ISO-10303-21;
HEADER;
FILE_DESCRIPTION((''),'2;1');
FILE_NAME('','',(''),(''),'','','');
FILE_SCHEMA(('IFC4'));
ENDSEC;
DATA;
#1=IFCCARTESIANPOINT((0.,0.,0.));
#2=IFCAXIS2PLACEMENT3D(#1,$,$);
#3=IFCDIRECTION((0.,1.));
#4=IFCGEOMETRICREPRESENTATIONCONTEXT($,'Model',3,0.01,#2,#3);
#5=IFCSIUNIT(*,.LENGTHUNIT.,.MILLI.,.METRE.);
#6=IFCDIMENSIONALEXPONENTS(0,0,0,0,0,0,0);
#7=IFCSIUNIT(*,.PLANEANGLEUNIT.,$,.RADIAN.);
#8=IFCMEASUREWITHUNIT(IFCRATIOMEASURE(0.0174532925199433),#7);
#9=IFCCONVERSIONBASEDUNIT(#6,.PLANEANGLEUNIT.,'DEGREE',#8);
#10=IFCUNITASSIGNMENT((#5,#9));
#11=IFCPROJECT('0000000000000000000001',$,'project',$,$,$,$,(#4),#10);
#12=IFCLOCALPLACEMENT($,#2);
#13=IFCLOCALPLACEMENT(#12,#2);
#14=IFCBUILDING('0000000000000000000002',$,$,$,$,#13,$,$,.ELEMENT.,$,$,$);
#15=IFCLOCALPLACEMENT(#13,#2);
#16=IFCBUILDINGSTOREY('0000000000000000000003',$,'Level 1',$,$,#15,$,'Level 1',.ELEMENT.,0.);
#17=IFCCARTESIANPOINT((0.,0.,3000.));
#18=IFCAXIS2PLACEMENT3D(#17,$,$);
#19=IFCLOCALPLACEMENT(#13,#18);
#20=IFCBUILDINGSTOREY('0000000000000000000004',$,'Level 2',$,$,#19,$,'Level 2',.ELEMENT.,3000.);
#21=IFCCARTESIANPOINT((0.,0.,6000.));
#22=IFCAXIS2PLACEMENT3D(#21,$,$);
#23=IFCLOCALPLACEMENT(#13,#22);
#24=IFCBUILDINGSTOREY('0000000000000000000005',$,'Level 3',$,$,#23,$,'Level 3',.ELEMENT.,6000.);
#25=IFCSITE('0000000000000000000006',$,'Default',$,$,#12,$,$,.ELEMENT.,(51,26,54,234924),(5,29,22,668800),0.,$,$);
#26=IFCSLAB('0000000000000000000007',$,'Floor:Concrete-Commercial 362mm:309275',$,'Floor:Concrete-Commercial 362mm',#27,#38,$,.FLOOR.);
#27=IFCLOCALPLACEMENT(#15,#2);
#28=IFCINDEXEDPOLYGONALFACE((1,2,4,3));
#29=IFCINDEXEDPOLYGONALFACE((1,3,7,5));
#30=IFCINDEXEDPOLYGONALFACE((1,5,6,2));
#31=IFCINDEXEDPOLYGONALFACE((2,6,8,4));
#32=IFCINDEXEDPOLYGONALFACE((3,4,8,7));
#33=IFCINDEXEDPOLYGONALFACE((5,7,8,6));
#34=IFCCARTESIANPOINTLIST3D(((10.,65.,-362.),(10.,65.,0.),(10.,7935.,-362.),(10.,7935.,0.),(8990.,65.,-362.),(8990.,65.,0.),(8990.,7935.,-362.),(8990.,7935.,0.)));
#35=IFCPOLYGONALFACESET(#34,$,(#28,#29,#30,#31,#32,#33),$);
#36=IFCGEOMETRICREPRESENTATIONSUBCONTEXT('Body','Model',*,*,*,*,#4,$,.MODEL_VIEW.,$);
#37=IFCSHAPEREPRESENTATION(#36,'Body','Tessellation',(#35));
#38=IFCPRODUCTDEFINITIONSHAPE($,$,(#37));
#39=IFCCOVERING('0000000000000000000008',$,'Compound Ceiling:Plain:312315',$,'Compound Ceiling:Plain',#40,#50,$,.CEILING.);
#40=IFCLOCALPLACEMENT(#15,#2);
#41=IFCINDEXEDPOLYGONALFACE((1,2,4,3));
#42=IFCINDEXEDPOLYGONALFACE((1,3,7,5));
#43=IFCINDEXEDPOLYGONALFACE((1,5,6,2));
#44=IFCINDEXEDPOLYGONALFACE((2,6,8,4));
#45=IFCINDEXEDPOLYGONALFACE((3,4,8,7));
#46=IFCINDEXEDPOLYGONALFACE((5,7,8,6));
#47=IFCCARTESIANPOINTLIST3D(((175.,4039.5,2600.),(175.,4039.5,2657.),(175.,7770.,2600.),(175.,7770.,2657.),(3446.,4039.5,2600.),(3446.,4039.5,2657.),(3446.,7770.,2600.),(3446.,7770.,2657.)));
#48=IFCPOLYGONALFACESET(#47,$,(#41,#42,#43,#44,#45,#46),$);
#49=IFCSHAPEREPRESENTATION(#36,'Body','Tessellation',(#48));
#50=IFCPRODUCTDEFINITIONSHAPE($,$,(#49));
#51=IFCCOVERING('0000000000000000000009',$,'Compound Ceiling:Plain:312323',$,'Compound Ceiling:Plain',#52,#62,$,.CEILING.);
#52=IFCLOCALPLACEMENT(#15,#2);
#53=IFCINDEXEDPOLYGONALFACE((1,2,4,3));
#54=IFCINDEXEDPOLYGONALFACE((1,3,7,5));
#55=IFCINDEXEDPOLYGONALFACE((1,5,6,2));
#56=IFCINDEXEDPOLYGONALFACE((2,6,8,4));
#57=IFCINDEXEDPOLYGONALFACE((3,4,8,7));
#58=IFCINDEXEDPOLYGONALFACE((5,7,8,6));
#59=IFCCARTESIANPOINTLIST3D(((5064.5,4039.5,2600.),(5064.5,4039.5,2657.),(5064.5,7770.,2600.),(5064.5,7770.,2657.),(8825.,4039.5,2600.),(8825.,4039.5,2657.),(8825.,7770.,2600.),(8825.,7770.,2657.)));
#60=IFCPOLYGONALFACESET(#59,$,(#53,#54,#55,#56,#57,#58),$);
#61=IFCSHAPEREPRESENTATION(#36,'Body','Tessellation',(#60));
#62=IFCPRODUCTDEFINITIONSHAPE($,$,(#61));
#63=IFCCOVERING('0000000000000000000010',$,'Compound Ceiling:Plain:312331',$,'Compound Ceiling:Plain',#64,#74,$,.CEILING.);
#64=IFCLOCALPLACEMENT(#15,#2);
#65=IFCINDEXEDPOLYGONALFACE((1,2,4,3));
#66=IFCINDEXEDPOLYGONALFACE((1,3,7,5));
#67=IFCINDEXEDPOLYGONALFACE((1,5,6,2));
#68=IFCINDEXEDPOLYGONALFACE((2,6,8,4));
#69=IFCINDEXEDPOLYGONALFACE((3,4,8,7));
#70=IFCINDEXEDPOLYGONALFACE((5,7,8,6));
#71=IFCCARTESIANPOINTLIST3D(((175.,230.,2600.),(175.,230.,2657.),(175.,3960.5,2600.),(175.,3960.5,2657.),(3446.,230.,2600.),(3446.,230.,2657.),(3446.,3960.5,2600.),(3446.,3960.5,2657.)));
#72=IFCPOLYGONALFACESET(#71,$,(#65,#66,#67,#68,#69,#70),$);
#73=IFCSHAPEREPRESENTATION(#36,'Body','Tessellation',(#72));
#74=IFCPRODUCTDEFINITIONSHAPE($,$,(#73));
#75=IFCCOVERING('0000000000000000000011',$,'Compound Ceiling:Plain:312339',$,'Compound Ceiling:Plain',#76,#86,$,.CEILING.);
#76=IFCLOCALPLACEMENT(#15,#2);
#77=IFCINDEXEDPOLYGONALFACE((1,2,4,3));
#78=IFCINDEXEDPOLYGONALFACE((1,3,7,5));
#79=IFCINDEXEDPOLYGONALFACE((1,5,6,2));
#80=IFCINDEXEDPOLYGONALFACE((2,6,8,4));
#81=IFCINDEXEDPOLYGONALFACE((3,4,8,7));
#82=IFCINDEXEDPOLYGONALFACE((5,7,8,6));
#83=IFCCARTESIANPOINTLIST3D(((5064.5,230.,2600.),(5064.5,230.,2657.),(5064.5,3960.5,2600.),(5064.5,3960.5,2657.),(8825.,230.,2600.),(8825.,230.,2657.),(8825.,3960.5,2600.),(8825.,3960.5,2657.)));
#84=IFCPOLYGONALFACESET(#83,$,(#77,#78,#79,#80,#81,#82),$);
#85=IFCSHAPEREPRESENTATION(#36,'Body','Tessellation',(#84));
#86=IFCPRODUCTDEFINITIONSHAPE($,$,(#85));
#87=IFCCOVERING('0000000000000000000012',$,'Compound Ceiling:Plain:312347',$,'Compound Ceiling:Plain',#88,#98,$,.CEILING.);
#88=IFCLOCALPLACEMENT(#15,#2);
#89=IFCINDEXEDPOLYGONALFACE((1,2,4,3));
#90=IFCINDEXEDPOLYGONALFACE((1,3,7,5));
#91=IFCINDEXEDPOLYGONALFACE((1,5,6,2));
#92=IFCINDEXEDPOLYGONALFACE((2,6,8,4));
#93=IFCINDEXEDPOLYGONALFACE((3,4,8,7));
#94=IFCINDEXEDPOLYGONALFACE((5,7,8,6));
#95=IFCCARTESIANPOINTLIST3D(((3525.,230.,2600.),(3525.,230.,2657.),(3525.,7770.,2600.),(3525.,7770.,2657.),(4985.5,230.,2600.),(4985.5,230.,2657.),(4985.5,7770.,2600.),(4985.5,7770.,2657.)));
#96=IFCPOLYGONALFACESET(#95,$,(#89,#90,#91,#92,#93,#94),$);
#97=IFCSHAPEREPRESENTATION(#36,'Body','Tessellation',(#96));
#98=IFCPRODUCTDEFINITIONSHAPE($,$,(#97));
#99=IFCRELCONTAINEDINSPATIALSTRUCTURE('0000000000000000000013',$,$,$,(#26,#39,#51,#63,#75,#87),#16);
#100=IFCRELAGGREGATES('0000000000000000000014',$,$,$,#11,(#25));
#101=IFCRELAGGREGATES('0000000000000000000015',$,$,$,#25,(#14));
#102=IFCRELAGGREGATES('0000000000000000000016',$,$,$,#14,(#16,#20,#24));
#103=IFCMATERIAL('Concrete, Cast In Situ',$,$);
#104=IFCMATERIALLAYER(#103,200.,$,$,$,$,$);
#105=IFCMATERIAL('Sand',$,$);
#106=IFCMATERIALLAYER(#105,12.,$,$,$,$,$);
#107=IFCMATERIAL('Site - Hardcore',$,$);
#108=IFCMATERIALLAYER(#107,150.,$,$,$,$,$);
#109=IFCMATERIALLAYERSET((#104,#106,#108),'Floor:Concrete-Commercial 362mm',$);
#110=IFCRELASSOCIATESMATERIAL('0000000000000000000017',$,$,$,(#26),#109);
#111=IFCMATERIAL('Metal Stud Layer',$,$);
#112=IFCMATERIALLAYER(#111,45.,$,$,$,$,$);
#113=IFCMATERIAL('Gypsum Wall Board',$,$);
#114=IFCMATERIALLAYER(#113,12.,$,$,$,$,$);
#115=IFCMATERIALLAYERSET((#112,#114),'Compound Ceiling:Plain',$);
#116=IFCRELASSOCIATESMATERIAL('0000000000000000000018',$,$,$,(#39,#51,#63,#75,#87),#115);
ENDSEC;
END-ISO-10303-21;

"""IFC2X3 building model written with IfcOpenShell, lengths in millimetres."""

from ifc_helpers import new_model, entity, si_unit, converted_unit, direction, frame, frame_2d, origin, origin_2d_with_axis, place, context, subcontext, project, spatial, rectangle, extrude, material, layer, layer_set, layer_usage, element, save


model = new_model("IFC2X3")

# Units and contexts
model_context = context("Model", 3, precision=0.01, world=origin(), true_north=direction((0.0, 1.0)))
body_context = subcontext(model_context, "Body", "Model", "MODEL_VIEW")
ifc_project = project(units=[si_unit("LENGTHUNIT", "METRE", prefix="MILLI"), converted_unit("PLANEANGLEUNIT", "DEGREE", entity("IfcRatioMeasure", 0.0174532925199433), si_unit("PLANEANGLEUNIT", "RADIAN"), dimensions=[0, 0, 0, 0, 0, 0, 0])], contexts=[model_context])

# Site, building, storey
site_placement = place(None, origin())
site = spatial("IfcSite", under=ifc_project, at=site_placement, Name="Default", CompositionType="ELEMENT", RefLatitude=(51, 26, 54, 234924), RefLongitude=(5, 29, 22, 668800), RefElevation=0.0)
building_placement = place(site_placement, origin())
building = spatial("IfcBuilding", under=site, at=building_placement, CompositionType="ELEMENT")
storey_1_placement = place(building_placement, origin())
storey_1 = spatial("IfcBuildingStorey", under=building, at=storey_1_placement, Name="Level 1", LongName="Level 1", CompositionType="ELEMENT", Elevation=0.0)

# Slab
ifc_material_1 = material(Name="Concrete, Cast In Situ")
ifc_layer_1 = layer(ifc_material_1, 200.0)
ifc_material_2 = material(Name="Sand")
ifc_layer_2 = layer(ifc_material_2, 12.0)
ifc_material_3 = material(Name="Site - Hardcore")
ifc_layer_3 = layer(ifc_material_3, 150.0)
ifc_layer_set_1 = layer_set([ifc_layer_1, ifc_layer_2, ifc_layer_3], Name="Floor:Concrete-Commercial 362mm")
ifc_layer_usage_1 = layer_usage(ifc_layer_set_1, "AXIS3", "POSITIVE", 0.0)
slab_placement = place(storey_1_placement, origin())
element("IfcSlab", 1, at=slab_placement, inside=storey_1, material=ifc_layer_usage_1, Name="Floor:Concrete-Commercial 362mm:309275", ObjectType="Floor:Concrete-Commercial 362mm", PredefinedType="FLOOR", context=body_context, shape_type="SweptSolid", body=[
    extrude(rectangle(XDim=7870.0, YDim=8980.0, at=frame_2d((0.0, 0.0), x_axis=(1.0, 0.0))), frame((4500.0, 4000.0, 0.0), z_axis=(0.0, 0.0, -1.0), x_axis=(0.0, 1.0, 0.0)), (0.0, 0.0, 1.0), 362.0),
])

# Shared definitions
ifc_material_4 = material(Name="Metal Stud Layer")
ifc_material_5 = material(Name="Gypsum Wall Board")

# Shared definitions
storey_2_placement = place(building_placement, frame((0.0, 0.0, 3000.0)))
storey_2 = spatial("IfcBuildingStorey", under=building, at=storey_2_placement, Name="Level 2", LongName="Level 2", CompositionType="ELEMENT", Elevation=3000.0)

# Shared definitions
storey_3_placement = place(building_placement, frame((0.0, 0.0, 6000.0)))
storey_3 = spatial("IfcBuildingStorey", under=building, at=storey_3_placement, Name="Level 3", LongName="Level 3", CompositionType="ELEMENT", Elevation=6000.0)

# Coverings
ifc_layer_4 = layer(ifc_material_4, 45.0)
ifc_layer_5 = layer(ifc_material_5, 12.0)
ifc_layer_set_2 = layer_set([ifc_layer_4, ifc_layer_5], Name="Compound Ceiling:Plain")
ifc_layer_usage_2 = layer_usage(ifc_layer_set_2, "AXIS3", "NEGATIVE", 0.0)
covering_1_placement = place(storey_1_placement, origin())
element("IfcCovering", 2, at=covering_1_placement, inside=storey_1, material=ifc_layer_usage_2, Name="Compound Ceiling:Plain:312315", ObjectType="Compound Ceiling:Plain", PredefinedType="CEILING", context=body_context, shape_type="SweptSolid", body=[
    extrude(rectangle(XDim=3271.0, YDim=3730.5, at=frame_2d((0.0, 0.0), x_axis=(1.0, 0.0))), frame((1810.5, 5904.8, 2600.0)), (0.0, 0.0, 1.0), 57.0),
])
ifc_layer_usage_3 = layer_usage(ifc_layer_set_2, "AXIS3", "NEGATIVE", 0.0)
covering_2_placement = place(storey_1_placement, origin())
element("IfcCovering", 3, at=covering_2_placement, inside=storey_1, material=ifc_layer_usage_3, Name="Compound Ceiling:Plain:312323", ObjectType="Compound Ceiling:Plain", PredefinedType="CEILING", context=body_context, shape_type="SweptSolid", body=[
    extrude(rectangle(XDim=3730.5, YDim=3760.5, at=frame_2d((0.0, 0.0), x_axis=(1.0, 0.0))), frame((6944.8, 5904.7, 2600.0), z_axis=(0.0, 0.0, 1.0), x_axis=(0.0, -1.0, 0.0)), (0.0, 0.0, 1.0), 57.0),
])
ifc_layer_usage_4 = layer_usage(ifc_layer_set_2, "AXIS3", "NEGATIVE", 0.0)
covering_3_placement = place(storey_1_placement, origin())
element("IfcCovering", 4, at=covering_3_placement, inside=storey_1, material=ifc_layer_usage_4, Name="Compound Ceiling:Plain:312331", ObjectType="Compound Ceiling:Plain", PredefinedType="CEILING", context=body_context, shape_type="SweptSolid", body=[
    extrude(rectangle(XDim=3271.0, YDim=3730.5, at=origin_2d_with_axis()), frame((1810.5, 2095.2, 2600.0)), (0.0, 0.0, 1.0), 57.0),
])
ifc_layer_usage_5 = layer_usage(ifc_layer_set_2, "AXIS3", "NEGATIVE", 0.0)
covering_4_placement = place(storey_1_placement, origin())
element("IfcCovering", 5, at=covering_4_placement, inside=storey_1, material=ifc_layer_usage_5, Name="Compound Ceiling:Plain:312339", ObjectType="Compound Ceiling:Plain", PredefinedType="CEILING", context=body_context, shape_type="SweptSolid", body=[
    extrude(rectangle(XDim=3760.5, YDim=3730.5, at=frame_2d((0.0, 0.0), x_axis=(1.0, 0.0))), frame((6944.8, 2095.2, 2600.0), z_axis=(0.0, 0.0, 1.0), x_axis=(-1.0, 0.0, 0.0)), (0.0, 0.0, 1.0), 57.0),
])
ifc_layer_usage_6 = layer_usage(ifc_layer_set_2, "AXIS3", "NEGATIVE", 0.0)
covering_5_placement = place(storey_1_placement, origin())
element("IfcCovering", 6, at=covering_5_placement, inside=storey_1, material=ifc_layer_usage_6, Name="Compound Ceiling:Plain:312347", ObjectType="Compound Ceiling:Plain", PredefinedType="CEILING", context=body_context, shape_type="SweptSolid", body=[
    extrude(rectangle(XDim=1460.5, YDim=7540.0, at=frame_2d((0.0, 0.0), x_axis=(1.0, 0.0))), frame((4255.3, 4000.0, 2600.0)), (0.0, 0.0, 1.0), 57.0),
])

save(model, "model.ifc")
